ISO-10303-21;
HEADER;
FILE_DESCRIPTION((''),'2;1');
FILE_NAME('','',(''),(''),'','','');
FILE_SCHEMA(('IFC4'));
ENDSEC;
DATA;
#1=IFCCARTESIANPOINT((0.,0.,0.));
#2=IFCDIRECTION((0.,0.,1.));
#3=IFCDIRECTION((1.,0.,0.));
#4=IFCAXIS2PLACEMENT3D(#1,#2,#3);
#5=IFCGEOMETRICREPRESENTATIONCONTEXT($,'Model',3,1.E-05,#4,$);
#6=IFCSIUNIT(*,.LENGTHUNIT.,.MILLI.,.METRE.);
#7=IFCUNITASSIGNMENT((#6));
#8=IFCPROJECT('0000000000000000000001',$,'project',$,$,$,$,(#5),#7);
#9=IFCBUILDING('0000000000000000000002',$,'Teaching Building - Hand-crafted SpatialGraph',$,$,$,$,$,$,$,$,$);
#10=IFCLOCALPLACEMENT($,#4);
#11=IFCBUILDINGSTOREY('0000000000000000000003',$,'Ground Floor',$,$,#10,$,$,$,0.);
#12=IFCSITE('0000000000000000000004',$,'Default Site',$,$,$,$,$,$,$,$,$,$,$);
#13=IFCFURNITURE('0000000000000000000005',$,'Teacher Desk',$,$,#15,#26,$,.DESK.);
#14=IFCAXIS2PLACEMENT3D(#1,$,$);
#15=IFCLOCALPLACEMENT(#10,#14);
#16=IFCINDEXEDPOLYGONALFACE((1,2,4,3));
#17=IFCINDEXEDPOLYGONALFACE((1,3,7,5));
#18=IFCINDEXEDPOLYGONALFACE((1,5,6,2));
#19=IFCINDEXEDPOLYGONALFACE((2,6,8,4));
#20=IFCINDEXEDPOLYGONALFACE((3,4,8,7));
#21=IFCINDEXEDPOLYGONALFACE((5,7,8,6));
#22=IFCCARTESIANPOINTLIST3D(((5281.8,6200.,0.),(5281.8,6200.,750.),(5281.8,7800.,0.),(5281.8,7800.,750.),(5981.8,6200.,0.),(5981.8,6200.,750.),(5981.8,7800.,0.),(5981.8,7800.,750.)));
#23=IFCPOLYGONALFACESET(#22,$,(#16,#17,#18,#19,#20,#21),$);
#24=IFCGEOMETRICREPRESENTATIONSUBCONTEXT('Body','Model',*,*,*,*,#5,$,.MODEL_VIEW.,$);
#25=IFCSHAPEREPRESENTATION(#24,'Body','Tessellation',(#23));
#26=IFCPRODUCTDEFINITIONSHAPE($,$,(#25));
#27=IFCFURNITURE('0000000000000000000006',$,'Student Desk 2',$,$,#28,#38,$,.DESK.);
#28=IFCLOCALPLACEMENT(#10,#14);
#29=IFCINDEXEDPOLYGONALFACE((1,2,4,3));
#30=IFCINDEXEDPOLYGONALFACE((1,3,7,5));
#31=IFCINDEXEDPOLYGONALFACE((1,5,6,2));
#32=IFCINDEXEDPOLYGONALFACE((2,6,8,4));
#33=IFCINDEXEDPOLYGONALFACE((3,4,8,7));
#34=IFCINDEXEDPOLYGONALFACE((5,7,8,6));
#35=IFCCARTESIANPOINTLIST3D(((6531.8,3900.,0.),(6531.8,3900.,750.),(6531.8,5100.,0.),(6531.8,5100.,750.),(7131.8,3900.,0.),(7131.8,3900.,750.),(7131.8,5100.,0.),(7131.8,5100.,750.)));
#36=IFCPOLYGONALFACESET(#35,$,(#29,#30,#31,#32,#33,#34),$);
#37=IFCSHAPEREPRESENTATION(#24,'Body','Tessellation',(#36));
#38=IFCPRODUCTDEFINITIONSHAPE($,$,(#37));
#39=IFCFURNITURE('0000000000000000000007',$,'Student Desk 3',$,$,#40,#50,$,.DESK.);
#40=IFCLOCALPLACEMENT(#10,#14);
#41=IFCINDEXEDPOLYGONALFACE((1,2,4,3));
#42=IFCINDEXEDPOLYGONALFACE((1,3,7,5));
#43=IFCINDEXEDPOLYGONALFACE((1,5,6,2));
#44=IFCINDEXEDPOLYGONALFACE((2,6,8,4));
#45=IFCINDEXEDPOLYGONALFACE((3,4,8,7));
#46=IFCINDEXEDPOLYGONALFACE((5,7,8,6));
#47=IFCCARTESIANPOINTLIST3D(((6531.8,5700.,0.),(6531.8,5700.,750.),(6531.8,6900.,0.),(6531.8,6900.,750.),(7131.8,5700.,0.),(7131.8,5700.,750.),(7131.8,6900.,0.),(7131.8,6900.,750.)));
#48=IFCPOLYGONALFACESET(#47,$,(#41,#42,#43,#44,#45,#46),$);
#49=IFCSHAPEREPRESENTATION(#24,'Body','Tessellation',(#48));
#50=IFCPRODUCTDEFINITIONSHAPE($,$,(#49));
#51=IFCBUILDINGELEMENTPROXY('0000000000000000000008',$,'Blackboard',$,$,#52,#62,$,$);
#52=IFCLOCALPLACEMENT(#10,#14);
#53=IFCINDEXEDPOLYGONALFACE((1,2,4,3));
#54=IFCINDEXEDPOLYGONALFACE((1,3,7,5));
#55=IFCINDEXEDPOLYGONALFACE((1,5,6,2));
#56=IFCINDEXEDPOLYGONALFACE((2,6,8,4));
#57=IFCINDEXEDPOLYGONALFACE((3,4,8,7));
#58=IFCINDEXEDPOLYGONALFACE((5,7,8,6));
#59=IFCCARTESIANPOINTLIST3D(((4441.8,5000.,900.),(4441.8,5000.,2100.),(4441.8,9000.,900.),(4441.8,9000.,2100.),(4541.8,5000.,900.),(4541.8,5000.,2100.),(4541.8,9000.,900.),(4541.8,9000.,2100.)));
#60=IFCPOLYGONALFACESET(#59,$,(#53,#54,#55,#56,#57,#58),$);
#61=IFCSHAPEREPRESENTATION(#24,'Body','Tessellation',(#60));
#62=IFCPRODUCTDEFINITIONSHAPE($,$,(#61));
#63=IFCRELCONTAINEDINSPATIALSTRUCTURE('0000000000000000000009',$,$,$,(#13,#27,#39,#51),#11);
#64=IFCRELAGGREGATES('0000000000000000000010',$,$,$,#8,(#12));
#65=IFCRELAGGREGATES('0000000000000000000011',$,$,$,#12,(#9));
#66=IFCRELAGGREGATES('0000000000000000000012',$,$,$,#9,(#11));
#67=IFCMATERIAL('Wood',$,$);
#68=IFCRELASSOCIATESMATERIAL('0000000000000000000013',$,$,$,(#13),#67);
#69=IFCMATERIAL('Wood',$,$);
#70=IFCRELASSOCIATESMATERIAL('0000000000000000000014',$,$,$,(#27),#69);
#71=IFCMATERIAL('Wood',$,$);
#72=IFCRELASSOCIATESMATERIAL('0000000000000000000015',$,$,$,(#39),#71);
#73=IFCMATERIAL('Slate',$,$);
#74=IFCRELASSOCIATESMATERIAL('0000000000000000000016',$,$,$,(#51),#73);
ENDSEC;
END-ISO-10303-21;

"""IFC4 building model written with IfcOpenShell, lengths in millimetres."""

from ifc_helpers import new_model, si_unit, frame, origin_with_axes, origin_2d, place, context, subcontext, project, spatial, rectangle, extrude, material, element, save


model = new_model("IFC4")

# Units and contexts
model_context = context("Model", 3, precision=1e-05, world=origin_with_axes())
body_context = subcontext(model_context, "Body", "Model", "MODEL_VIEW")
ifc_project = project(units=[si_unit("LENGTHUNIT", "METRE", prefix="MILLI")], contexts=[model_context])

# Site, building, storey
site = spatial("IfcSite", under=ifc_project, Name="Default Site")
building = spatial("IfcBuilding", under=site, Name="Teaching Building - Hand-crafted SpatialGraph")
storey_placement = place(None, origin_with_axes())
storey = spatial("IfcBuildingStorey", under=building, at=storey_placement, Name="Ground Floor", Elevation=0.0)

# Furniture
ifc_material_1 = material(Name="Wood")
furniture_1_placement = place(storey_placement, frame((5631.8, 7000.0, 0.0), z_axis=(0.0, 0.0, 1.0), x_axis=(0.0, 1.0, 0.0)))
element("IfcFurniture", 1, at=furniture_1_placement, inside=storey, material=ifc_material_1, Name="Teacher Desk", PredefinedType="DESK", context=body_context, shape_type="SweptSolid", body=[
    extrude(rectangle(XDim=1600.0, YDim=700.0, at=origin_2d()), origin_with_axes(), (0.0, 0.0, 1.0), 750.0),
])
ifc_material_2 = material(Name="Wood")
furniture_2_placement = place(storey_placement, frame((6831.8, 4500.0, 0.0), z_axis=(0.0, 0.0, 1.0), x_axis=(0.0, 1.0, 0.0)))
element("IfcFurniture", 2, at=furniture_2_placement, inside=storey, material=ifc_material_2, Name="Student Desk 2", PredefinedType="DESK", context=body_context, shape_type="SweptSolid", body=[
    extrude(rectangle(XDim=1200.0, YDim=600.0, at=origin_2d()), origin_with_axes(), (0.0, 0.0, 1.0), 750.0),
])
ifc_material_3 = material(Name="Wood")
furniture_3_placement = place(storey_placement, frame((6831.8, 6300.0, 0.0), z_axis=(0.0, 0.0, 1.0), x_axis=(0.0, 1.0, 0.0)))
element("IfcFurniture", 3, at=furniture_3_placement, inside=storey, material=ifc_material_3, Name="Student Desk 3", PredefinedType="DESK", context=body_context, shape_type="SweptSolid", body=[
    extrude(rectangle(XDim=1200.0, YDim=600.0, at=origin_2d()), origin_with_axes(), (0.0, 0.0, 1.0), 750.0),
])

# Building element proxy
ifc_material_4 = material(Name="Slate")
proxy_placement = place(storey_placement, frame((4491.8, 7000.0, 900.0), z_axis=(0.0, 0.0, 1.0), x_axis=(1.0, 0.0, 0.0)))
element("IfcBuildingElementProxy", 4, at=proxy_placement, inside=storey, material=ifc_material_4, Name="Blackboard", context=body_context, shape_type="SweptSolid", body=[
    extrude(rectangle(XDim=100.0, YDim=4000.0, at=origin_2d()), origin_with_axes(), (0.0, 0.0, 1.0), 1200.0),
])

save(model, "model.ifc")
